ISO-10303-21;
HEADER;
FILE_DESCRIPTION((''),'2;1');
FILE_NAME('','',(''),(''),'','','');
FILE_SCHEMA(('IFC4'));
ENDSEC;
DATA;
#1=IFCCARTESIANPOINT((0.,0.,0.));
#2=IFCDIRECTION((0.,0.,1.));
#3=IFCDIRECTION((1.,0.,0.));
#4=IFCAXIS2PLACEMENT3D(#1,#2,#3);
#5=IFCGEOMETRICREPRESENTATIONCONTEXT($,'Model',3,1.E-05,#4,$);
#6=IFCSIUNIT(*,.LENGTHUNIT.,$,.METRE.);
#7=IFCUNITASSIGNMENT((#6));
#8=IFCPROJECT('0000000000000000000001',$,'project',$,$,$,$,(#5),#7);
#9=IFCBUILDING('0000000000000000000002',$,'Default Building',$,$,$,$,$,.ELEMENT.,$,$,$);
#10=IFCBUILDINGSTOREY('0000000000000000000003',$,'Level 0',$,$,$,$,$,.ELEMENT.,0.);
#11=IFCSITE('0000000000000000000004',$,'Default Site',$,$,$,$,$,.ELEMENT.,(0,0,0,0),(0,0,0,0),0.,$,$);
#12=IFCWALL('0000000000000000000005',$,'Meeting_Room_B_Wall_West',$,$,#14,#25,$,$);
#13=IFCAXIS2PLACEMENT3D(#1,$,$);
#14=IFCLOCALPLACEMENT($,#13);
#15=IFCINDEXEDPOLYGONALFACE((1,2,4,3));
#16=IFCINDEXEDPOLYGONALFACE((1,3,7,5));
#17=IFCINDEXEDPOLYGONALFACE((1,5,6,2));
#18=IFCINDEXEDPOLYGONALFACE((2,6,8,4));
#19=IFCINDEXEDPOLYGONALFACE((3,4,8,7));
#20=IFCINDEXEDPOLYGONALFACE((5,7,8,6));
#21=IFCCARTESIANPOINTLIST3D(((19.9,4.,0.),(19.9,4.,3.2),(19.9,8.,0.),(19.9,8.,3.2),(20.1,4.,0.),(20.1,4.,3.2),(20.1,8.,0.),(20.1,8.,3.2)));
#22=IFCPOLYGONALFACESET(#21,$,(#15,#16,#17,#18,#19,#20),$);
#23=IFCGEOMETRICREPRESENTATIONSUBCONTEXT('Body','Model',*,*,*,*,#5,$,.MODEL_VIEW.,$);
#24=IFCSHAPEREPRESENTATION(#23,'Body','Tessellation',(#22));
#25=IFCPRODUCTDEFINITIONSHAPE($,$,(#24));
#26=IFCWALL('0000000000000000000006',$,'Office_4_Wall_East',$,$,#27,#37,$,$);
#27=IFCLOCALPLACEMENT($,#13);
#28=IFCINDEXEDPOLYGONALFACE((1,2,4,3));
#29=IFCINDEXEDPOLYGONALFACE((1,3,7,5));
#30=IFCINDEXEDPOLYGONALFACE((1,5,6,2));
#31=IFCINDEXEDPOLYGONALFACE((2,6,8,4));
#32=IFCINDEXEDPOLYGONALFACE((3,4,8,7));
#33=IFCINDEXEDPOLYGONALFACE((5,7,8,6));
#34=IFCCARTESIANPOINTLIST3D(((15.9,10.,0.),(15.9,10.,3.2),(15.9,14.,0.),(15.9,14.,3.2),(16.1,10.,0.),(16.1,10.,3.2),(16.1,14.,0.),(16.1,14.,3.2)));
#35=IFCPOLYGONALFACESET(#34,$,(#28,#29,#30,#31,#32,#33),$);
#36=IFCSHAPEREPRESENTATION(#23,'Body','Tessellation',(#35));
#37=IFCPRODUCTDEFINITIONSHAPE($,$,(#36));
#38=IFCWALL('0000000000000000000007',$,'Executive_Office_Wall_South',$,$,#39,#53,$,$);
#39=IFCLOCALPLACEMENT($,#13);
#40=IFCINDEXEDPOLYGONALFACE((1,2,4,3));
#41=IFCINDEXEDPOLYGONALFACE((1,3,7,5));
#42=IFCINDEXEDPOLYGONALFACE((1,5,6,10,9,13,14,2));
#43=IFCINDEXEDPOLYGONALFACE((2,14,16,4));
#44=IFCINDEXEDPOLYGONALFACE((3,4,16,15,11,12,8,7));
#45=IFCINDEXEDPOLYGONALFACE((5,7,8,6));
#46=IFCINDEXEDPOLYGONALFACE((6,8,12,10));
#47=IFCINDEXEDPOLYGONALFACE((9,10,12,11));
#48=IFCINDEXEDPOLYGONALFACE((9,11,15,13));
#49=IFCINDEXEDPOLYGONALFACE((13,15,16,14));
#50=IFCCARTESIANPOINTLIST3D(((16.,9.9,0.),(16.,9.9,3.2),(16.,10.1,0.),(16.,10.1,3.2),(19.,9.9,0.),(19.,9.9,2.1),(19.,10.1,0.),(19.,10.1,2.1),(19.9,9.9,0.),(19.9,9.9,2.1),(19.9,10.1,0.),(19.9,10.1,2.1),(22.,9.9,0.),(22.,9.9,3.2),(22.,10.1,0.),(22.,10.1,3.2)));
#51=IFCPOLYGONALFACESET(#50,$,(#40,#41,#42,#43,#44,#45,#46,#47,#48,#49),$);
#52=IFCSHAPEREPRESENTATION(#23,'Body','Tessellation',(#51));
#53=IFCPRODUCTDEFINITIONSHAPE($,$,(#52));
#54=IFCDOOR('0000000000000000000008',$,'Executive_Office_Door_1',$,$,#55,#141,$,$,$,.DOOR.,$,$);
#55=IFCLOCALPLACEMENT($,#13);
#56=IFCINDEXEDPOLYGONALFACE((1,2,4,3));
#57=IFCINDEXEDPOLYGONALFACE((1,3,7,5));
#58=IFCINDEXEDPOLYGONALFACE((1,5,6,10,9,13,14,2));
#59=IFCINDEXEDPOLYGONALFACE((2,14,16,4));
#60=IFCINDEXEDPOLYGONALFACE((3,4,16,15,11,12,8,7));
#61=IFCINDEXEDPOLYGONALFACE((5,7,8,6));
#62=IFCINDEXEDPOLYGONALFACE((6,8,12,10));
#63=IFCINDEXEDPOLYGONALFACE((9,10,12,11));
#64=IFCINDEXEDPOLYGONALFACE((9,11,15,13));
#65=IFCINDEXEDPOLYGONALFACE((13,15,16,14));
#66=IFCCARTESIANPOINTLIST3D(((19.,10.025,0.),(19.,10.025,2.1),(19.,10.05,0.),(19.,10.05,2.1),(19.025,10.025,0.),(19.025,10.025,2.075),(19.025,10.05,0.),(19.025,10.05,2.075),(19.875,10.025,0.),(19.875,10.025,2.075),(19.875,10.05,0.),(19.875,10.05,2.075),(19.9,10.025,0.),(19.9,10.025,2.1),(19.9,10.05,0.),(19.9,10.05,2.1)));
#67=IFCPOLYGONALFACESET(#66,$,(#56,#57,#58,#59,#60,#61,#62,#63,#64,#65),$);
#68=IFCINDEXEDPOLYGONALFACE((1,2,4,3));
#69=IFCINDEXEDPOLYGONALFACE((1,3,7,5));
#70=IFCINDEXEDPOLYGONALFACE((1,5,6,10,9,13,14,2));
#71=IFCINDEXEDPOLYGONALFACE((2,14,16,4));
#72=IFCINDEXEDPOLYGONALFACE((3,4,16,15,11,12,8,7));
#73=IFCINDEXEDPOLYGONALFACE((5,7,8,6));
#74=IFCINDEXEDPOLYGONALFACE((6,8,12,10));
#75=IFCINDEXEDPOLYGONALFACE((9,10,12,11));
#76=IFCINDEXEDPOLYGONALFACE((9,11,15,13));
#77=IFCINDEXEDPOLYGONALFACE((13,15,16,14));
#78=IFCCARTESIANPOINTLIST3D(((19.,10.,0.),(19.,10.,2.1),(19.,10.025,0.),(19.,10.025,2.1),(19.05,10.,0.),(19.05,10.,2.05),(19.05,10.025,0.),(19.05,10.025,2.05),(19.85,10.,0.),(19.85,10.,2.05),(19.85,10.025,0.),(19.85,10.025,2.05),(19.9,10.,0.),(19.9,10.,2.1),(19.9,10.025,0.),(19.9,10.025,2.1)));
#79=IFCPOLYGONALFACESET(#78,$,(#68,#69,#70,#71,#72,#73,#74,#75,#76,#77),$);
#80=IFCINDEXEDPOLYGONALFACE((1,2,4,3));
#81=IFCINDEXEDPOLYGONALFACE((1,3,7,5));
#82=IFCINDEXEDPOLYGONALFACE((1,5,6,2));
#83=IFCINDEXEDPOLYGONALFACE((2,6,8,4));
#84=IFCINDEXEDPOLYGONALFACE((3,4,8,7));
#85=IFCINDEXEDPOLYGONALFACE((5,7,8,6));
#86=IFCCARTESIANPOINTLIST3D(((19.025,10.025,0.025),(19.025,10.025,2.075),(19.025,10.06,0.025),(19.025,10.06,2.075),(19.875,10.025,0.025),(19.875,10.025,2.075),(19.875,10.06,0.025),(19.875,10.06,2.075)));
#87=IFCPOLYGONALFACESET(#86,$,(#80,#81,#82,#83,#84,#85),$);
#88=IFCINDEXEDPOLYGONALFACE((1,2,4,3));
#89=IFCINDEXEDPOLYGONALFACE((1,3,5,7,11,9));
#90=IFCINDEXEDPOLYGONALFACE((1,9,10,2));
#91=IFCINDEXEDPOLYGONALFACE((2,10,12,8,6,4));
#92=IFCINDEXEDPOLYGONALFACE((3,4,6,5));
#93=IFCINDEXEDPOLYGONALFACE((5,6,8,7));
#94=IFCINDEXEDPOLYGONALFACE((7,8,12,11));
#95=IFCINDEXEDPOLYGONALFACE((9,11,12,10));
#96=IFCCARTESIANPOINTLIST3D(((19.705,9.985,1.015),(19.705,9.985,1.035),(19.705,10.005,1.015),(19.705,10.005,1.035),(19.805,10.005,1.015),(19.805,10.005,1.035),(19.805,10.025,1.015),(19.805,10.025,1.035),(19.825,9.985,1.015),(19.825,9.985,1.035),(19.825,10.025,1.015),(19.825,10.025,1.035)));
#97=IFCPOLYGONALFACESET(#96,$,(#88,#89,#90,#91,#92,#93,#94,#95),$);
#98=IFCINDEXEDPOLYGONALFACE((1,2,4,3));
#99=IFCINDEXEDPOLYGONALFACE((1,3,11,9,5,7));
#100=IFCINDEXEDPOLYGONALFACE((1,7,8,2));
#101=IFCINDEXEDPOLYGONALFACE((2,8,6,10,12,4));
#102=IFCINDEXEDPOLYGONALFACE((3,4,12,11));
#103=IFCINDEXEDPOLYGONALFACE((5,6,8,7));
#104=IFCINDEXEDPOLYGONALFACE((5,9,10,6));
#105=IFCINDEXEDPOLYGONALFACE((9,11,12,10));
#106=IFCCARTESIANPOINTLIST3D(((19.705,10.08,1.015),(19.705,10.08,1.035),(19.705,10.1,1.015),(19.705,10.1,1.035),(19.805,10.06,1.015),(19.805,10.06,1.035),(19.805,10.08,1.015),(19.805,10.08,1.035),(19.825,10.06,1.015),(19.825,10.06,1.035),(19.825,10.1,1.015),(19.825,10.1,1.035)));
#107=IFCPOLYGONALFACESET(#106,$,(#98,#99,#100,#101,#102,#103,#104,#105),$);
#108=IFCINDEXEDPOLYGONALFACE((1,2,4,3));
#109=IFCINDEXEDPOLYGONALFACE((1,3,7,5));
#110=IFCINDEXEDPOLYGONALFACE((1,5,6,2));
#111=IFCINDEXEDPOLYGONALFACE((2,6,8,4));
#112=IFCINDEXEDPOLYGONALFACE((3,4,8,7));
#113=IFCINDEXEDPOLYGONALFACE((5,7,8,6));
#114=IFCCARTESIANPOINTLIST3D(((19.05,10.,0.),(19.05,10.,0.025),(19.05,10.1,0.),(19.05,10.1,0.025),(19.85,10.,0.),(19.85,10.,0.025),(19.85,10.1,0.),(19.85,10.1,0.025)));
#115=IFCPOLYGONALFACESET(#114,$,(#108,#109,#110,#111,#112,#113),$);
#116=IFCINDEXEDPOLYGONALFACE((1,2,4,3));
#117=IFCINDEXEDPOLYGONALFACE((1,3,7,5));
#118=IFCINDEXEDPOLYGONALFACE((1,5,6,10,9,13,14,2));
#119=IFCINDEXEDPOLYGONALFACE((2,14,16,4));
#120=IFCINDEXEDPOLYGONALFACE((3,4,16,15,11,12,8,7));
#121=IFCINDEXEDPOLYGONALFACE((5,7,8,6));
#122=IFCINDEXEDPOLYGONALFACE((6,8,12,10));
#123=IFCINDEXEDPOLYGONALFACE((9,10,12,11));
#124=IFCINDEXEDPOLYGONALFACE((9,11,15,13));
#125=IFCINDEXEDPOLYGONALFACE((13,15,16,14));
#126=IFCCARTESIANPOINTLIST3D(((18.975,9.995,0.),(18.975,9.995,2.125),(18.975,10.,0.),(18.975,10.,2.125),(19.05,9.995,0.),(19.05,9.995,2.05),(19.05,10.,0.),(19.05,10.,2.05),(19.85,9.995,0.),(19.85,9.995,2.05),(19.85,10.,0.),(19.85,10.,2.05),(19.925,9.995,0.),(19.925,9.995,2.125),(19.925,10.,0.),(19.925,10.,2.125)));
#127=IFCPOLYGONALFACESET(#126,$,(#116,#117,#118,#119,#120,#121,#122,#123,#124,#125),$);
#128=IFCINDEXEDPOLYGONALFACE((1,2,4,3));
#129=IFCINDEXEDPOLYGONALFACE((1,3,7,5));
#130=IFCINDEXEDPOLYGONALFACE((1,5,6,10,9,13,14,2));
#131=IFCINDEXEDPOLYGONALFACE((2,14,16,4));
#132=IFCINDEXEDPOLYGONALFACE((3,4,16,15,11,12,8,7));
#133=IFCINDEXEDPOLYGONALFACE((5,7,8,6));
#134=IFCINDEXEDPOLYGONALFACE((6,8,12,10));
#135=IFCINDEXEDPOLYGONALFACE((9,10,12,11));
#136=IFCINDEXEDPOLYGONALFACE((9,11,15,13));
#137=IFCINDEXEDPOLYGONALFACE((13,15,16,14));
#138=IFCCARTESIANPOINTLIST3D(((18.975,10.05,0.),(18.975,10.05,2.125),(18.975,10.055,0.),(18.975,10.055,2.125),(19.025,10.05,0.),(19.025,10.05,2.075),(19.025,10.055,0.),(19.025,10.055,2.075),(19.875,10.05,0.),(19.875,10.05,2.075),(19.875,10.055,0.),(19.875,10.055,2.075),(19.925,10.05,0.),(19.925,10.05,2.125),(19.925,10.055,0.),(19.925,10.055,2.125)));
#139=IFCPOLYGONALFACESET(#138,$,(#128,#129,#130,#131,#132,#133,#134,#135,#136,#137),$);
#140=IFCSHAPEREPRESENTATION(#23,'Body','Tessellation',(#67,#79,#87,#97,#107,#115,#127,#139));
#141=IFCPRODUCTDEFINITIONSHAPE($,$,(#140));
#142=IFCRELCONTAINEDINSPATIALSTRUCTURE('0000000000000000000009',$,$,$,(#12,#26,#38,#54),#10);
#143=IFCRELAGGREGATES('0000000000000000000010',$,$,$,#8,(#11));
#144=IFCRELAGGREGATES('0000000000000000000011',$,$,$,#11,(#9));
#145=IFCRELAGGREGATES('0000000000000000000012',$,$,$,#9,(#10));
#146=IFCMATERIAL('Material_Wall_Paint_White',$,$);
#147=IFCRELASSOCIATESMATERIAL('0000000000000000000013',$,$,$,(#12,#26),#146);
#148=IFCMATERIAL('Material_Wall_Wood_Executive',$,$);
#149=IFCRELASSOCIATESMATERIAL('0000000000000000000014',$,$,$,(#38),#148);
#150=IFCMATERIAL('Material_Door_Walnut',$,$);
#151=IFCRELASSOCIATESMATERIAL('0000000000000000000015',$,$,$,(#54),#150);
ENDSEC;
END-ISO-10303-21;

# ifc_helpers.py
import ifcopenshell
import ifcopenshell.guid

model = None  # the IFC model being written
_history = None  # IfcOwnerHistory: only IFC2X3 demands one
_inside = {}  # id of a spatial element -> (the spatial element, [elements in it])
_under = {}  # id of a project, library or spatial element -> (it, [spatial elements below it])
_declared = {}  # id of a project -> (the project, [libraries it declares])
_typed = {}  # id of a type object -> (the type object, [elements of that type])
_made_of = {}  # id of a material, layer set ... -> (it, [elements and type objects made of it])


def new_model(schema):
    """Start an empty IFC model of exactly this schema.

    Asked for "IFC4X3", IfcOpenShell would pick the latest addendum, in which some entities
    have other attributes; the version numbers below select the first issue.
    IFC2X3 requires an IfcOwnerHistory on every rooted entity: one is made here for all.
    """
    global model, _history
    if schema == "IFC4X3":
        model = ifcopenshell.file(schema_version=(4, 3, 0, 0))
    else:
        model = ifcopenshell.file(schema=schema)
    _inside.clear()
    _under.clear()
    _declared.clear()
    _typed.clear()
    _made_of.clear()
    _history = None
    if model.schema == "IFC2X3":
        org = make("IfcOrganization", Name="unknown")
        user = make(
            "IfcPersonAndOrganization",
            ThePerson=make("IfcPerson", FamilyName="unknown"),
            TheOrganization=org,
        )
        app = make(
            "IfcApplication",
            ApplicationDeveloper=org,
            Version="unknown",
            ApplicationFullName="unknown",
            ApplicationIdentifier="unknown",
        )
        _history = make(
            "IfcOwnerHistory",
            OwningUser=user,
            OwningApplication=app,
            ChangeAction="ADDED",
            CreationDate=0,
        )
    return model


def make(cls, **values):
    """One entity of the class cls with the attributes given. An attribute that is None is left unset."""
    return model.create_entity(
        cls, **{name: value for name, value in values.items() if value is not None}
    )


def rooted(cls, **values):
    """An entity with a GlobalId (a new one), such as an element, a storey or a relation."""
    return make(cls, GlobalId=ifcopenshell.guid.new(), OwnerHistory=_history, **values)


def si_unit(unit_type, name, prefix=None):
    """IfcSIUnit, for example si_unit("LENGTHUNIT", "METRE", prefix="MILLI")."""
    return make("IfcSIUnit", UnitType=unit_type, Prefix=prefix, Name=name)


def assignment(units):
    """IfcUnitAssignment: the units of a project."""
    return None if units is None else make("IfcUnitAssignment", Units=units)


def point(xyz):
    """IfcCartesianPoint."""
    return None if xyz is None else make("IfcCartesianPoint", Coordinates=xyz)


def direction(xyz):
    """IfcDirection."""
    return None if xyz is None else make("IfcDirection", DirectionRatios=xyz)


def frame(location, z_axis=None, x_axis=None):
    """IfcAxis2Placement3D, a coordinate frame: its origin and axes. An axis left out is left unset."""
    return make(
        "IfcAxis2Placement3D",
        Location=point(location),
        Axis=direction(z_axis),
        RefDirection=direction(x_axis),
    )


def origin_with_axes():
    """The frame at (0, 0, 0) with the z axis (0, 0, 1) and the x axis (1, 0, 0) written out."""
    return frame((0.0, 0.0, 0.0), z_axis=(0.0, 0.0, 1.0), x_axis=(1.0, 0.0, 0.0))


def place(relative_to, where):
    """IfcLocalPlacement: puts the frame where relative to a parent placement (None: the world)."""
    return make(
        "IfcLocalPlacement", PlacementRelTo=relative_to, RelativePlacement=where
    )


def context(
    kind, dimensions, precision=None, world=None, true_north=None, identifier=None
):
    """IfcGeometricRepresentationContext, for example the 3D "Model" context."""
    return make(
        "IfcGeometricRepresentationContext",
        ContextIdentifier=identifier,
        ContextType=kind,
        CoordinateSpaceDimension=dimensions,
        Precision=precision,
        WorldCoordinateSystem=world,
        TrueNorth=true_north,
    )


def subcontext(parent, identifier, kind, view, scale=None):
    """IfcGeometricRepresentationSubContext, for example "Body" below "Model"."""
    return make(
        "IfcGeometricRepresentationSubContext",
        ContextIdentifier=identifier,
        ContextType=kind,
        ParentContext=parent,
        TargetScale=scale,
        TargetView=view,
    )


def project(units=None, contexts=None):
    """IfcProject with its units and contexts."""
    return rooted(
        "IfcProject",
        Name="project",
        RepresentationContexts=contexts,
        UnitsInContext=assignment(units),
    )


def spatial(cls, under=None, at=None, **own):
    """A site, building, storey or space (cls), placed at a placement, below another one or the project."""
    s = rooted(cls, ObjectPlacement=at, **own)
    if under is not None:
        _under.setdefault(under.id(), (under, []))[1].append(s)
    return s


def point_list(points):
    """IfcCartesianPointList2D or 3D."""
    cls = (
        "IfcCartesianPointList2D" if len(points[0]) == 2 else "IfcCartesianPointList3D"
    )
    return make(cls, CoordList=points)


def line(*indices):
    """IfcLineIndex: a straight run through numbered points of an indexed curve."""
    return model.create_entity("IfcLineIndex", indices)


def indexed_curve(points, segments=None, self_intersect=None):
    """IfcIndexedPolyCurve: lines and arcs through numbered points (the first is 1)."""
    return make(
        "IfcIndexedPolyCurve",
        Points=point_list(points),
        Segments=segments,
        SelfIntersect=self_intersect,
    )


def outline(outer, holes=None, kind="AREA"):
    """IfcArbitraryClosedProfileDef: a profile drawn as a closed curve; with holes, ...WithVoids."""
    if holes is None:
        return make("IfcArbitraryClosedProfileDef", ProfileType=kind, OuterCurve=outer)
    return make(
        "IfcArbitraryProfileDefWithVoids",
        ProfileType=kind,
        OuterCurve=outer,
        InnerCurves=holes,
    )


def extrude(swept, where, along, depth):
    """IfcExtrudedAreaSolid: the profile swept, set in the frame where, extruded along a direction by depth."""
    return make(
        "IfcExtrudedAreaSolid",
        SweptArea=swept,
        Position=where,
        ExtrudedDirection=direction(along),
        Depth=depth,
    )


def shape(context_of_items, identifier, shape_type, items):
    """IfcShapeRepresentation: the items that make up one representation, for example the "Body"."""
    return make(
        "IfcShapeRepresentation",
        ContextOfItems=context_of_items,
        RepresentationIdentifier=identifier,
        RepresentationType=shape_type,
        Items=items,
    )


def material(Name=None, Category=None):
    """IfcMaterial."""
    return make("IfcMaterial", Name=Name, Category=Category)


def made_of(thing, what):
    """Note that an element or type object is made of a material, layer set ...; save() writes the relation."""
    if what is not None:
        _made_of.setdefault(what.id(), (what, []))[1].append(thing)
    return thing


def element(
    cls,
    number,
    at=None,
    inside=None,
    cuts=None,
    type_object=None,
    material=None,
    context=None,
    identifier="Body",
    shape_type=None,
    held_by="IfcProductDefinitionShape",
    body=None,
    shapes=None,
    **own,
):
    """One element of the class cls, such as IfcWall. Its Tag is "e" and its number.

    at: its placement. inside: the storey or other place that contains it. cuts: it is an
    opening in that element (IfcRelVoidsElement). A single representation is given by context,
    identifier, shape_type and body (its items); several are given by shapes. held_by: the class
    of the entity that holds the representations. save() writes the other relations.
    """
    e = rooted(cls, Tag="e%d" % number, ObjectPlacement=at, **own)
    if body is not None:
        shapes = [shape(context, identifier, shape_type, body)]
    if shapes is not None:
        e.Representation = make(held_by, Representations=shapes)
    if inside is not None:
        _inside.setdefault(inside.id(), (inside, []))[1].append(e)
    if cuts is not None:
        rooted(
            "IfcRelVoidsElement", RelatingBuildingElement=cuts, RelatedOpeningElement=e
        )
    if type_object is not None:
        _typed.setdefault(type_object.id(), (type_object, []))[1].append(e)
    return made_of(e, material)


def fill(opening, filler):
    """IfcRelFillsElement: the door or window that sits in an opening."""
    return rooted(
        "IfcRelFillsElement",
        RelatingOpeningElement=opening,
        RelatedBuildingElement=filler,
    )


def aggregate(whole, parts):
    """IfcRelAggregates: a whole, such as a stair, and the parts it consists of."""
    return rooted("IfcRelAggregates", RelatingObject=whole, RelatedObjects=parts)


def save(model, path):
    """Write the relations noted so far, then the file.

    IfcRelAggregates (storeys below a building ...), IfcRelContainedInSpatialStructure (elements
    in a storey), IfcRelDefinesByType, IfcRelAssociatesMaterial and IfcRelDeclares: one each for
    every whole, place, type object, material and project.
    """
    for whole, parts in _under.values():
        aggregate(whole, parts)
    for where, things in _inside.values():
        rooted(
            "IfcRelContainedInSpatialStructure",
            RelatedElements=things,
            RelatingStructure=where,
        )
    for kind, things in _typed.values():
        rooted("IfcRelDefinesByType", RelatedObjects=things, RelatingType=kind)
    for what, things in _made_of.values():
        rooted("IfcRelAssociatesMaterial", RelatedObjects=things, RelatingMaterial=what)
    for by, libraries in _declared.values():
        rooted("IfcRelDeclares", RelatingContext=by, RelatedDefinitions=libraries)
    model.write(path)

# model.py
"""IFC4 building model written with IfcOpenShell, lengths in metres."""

from ifc_helpers import new_model, si_unit, frame, origin_with_axes, place, context, subcontext, project, spatial, line, indexed_curve, outline, extrude, material, element, fill, save


model = new_model("IFC4")

# Units and contexts
model_context = context("Model", 3, precision=1e-05, world=origin_with_axes())
body_context = subcontext(model_context, "Body", "Model", "MODEL_VIEW")
ifc_project = project(units=[si_unit("LENGTHUNIT", "METRE")], contexts=[model_context])

# Site, building, storey
site = spatial("IfcSite", under=ifc_project, Name="Default Site", CompositionType="ELEMENT", RefLatitude=(0, 0, 0, 0), RefLongitude=(0, 0, 0, 0), RefElevation=0.0)
building = spatial("IfcBuilding", under=site, Name="Default Building", CompositionType="ELEMENT")
storey = spatial("IfcBuildingStorey", under=building, Name="Level 0", CompositionType="ELEMENT", Elevation=0.0)

# Shared definitions
ifc_material_1 = material(Name="Material_Wall_Paint_White")

# Shared definitions
ifc_material_2 = material(Name="Material_Door_Walnut")

# Walls
for number, where, z_axis, x_axis, name in (
    (1, (20.0, 8.0, 0.0), (0.0, 0.0, 1.0), (0.0, -1.0, 0.0), "Meeting_Room_B_Wall_West"),
    (2, (16.0, 10.0, 0.0), (0.0, 0.0, 1.0), (0.0, 1.0, 0.0), "Office_4_Wall_East"),
):
    element("IfcWall", number, at=place(None, frame(where, z_axis=z_axis, x_axis=x_axis)), inside=storey, material=ifc_material_1, Name=name, context=body_context, shape_type="SweptSolid", body=[
        extrude(outline(indexed_curve([(0.0, 0.0), (0.0, 0.2), (4.0, 0.2), (4.0, 0.0), (0.0, 0.0)], self_intersect=False)), frame((0.0, -0.1, 0.0), z_axis=(0.0, 0.0, 1.0), x_axis=(1.0, 0.0, 0.0)), (0.0, 0.0, 1.0), 3.2),
    ])

# Wall, opening, door
ifc_material_3 = material(Name="Material_Wall_Wood_Executive")
wall_1_placement = place(None, frame((16.0, 10.0, 0.0), z_axis=(0.0, 0.0, 1.0), x_axis=(1.0, 0.0, 0.0)))
wall_1 = element("IfcWall", 3, at=wall_1_placement, inside=storey, material=ifc_material_3, Name="Executive_Office_Wall_South", context=body_context, shape_type="SweptSolid", body=[
    extrude(outline(indexed_curve([(0.0, 0.0), (0.0, 0.2), (6.0, 0.2), (6.0, 0.0), (0.0, 0.0)], self_intersect=False)), frame((0.0, -0.1, 0.0), z_axis=(0.0, 0.0, 1.0), x_axis=(1.0, 0.0, 0.0)), (0.0, 0.0, 1.0), 3.2),
])
opening_1_placement = place(wall_1_placement, frame((3.0, -0.5, 0.0), z_axis=(0.0, 0.0, 1.0), x_axis=(1.0, 0.0, 0.0)))
opening_1 = element("IfcOpeningElement", 4, at=opening_1_placement, inside=storey, cuts=wall_1, PredefinedType="OPENING", context=body_context, shape_type="SweptSolid", body=[
    extrude(outline(indexed_curve([(0.0, 0.0), (0.0, 1.0), (0.9, 1.0), (0.9, 0.0), (0.0, 0.0)], self_intersect=False)), origin_with_axes(), (0.0, 0.0, 1.0), 2.1),
])
door_1_placement = place(None, frame((19.0, 10.0, 0.0), z_axis=(0.0, 0.0, 1.0), x_axis=(1.0, 0.0, 0.0)))
door_1 = element("IfcDoor", 5, at=door_1_placement, inside=storey, material=ifc_material_2, Name="Executive_Office_Door_1", PredefinedType="DOOR", context=body_context, shape_type="SweptSolid", body=[
    extrude(outline(indexed_curve([(0.0, 0.0), (0.0, 2.1), (0.9, 2.1), (0.9, 0.0), (0.875, 0.0), (0.875, 2.075), (0.025, 2.075), (0.025, 0.0)], segments=[line(1, 2, 3, 4, 5, 6, 7, 8, 1)])), frame((0.0, 0.025, 0.0), z_axis=(0.0, -1.0, 0.0), x_axis=(1.0, 0.0, 0.0)), (0.0, 0.0, -1.0), 0.025),
    extrude(outline(indexed_curve([(0.0, 0.0), (0.0, 2.1), (0.9, 2.1), (0.9, 0.0), (0.85, 0.0), (0.85, 2.05), (0.05, 2.05), (0.05, 0.0)], segments=[line(1, 2, 3, 4, 5, 6, 7, 8, 1)])), frame((0.0, 0.0, 0.0), z_axis=(0.0, -1.0, 0.0), x_axis=(1.0, 0.0, 0.0)), (0.0, 0.0, -1.0), 0.025),
    extrude(outline(indexed_curve([(0.0, 0.0), (0.85, 0.0), (0.85, 0.035), (0.0, 0.035)], segments=[line(1, 2, 3, 4, 1)])), frame((0.025, 0.025, 0.025), z_axis=(0.0, 0.0, 1.0), x_axis=(1.0, 0.0, 0.0)), (0.0, 0.0, 1.0), 2.05),
    extrude(outline(indexed_curve([(0.0, 0.0), (0.0, -0.04), (-0.12, -0.04), (-0.12, -0.02), (-0.02, -0.02), (-0.02, 0.0)], segments=[line(1, 2, 3, 4, 5, 6, 1)])), frame((0.825, 0.025, 1.015), z_axis=(0.0, 0.0, 1.0), x_axis=(1.0, 0.0, 0.0)), (0.0, 0.0, 1.0), 0.02),
    extrude(outline(indexed_curve([(0.0, 0.0), (0.0, 0.04), (-0.12, 0.04), (-0.12, 0.02), (-0.02, 0.02), (-0.02, 0.0)], segments=[line(1, 2, 3, 4, 5, 6, 1)])), frame((0.825, 0.06, 1.015), z_axis=(0.0, 0.0, 1.0), x_axis=(1.0, 0.0, 0.0)), (0.0, 0.0, 1.0), 0.02),
    extrude(outline(indexed_curve([(0.0, 0.0), (0.8, 0.0), (0.8, 0.1), (0.0, 0.1)], segments=[line(1, 2, 3, 4, 1)])), frame((0.05, 0.0, 0.0), z_axis=(0.0, 0.0, 1.0), x_axis=(1.0, 0.0, 0.0)), (0.0, 0.0, 1.0), 0.025),
    extrude(outline(indexed_curve([(0.0, 0.0), (0.0, 2.125), (0.95, 2.125), (0.95, 0.0), (0.875, 0.0), (0.875, 2.05), (0.075, 2.05), (0.075, 0.0)], segments=[line(1, 2, 3, 4, 5, 6, 7, 8, 1)])), frame((-0.025, -0.005, 0.0), z_axis=(0.0, -1.0, 0.0), x_axis=(1.0, 0.0, 0.0)), (0.0, 0.0, -1.0), 0.005),
    extrude(outline(indexed_curve([(0.0, 0.0), (0.0, 2.125), (0.95, 2.125), (0.95, 0.0), (0.9, 0.0), (0.9, 2.075), (0.05, 2.075), (0.05, 0.0)], segments=[line(1, 2, 3, 4, 5, 6, 7, 8, 1)])), frame((-0.025, 0.05, 0.0), z_axis=(0.0, -1.0, 0.0), x_axis=(1.0, 0.0, 0.0)), (0.0, 0.0, -1.0), 0.005),
])
fill(opening_1, door_1)

save(model, "model.ifc")
